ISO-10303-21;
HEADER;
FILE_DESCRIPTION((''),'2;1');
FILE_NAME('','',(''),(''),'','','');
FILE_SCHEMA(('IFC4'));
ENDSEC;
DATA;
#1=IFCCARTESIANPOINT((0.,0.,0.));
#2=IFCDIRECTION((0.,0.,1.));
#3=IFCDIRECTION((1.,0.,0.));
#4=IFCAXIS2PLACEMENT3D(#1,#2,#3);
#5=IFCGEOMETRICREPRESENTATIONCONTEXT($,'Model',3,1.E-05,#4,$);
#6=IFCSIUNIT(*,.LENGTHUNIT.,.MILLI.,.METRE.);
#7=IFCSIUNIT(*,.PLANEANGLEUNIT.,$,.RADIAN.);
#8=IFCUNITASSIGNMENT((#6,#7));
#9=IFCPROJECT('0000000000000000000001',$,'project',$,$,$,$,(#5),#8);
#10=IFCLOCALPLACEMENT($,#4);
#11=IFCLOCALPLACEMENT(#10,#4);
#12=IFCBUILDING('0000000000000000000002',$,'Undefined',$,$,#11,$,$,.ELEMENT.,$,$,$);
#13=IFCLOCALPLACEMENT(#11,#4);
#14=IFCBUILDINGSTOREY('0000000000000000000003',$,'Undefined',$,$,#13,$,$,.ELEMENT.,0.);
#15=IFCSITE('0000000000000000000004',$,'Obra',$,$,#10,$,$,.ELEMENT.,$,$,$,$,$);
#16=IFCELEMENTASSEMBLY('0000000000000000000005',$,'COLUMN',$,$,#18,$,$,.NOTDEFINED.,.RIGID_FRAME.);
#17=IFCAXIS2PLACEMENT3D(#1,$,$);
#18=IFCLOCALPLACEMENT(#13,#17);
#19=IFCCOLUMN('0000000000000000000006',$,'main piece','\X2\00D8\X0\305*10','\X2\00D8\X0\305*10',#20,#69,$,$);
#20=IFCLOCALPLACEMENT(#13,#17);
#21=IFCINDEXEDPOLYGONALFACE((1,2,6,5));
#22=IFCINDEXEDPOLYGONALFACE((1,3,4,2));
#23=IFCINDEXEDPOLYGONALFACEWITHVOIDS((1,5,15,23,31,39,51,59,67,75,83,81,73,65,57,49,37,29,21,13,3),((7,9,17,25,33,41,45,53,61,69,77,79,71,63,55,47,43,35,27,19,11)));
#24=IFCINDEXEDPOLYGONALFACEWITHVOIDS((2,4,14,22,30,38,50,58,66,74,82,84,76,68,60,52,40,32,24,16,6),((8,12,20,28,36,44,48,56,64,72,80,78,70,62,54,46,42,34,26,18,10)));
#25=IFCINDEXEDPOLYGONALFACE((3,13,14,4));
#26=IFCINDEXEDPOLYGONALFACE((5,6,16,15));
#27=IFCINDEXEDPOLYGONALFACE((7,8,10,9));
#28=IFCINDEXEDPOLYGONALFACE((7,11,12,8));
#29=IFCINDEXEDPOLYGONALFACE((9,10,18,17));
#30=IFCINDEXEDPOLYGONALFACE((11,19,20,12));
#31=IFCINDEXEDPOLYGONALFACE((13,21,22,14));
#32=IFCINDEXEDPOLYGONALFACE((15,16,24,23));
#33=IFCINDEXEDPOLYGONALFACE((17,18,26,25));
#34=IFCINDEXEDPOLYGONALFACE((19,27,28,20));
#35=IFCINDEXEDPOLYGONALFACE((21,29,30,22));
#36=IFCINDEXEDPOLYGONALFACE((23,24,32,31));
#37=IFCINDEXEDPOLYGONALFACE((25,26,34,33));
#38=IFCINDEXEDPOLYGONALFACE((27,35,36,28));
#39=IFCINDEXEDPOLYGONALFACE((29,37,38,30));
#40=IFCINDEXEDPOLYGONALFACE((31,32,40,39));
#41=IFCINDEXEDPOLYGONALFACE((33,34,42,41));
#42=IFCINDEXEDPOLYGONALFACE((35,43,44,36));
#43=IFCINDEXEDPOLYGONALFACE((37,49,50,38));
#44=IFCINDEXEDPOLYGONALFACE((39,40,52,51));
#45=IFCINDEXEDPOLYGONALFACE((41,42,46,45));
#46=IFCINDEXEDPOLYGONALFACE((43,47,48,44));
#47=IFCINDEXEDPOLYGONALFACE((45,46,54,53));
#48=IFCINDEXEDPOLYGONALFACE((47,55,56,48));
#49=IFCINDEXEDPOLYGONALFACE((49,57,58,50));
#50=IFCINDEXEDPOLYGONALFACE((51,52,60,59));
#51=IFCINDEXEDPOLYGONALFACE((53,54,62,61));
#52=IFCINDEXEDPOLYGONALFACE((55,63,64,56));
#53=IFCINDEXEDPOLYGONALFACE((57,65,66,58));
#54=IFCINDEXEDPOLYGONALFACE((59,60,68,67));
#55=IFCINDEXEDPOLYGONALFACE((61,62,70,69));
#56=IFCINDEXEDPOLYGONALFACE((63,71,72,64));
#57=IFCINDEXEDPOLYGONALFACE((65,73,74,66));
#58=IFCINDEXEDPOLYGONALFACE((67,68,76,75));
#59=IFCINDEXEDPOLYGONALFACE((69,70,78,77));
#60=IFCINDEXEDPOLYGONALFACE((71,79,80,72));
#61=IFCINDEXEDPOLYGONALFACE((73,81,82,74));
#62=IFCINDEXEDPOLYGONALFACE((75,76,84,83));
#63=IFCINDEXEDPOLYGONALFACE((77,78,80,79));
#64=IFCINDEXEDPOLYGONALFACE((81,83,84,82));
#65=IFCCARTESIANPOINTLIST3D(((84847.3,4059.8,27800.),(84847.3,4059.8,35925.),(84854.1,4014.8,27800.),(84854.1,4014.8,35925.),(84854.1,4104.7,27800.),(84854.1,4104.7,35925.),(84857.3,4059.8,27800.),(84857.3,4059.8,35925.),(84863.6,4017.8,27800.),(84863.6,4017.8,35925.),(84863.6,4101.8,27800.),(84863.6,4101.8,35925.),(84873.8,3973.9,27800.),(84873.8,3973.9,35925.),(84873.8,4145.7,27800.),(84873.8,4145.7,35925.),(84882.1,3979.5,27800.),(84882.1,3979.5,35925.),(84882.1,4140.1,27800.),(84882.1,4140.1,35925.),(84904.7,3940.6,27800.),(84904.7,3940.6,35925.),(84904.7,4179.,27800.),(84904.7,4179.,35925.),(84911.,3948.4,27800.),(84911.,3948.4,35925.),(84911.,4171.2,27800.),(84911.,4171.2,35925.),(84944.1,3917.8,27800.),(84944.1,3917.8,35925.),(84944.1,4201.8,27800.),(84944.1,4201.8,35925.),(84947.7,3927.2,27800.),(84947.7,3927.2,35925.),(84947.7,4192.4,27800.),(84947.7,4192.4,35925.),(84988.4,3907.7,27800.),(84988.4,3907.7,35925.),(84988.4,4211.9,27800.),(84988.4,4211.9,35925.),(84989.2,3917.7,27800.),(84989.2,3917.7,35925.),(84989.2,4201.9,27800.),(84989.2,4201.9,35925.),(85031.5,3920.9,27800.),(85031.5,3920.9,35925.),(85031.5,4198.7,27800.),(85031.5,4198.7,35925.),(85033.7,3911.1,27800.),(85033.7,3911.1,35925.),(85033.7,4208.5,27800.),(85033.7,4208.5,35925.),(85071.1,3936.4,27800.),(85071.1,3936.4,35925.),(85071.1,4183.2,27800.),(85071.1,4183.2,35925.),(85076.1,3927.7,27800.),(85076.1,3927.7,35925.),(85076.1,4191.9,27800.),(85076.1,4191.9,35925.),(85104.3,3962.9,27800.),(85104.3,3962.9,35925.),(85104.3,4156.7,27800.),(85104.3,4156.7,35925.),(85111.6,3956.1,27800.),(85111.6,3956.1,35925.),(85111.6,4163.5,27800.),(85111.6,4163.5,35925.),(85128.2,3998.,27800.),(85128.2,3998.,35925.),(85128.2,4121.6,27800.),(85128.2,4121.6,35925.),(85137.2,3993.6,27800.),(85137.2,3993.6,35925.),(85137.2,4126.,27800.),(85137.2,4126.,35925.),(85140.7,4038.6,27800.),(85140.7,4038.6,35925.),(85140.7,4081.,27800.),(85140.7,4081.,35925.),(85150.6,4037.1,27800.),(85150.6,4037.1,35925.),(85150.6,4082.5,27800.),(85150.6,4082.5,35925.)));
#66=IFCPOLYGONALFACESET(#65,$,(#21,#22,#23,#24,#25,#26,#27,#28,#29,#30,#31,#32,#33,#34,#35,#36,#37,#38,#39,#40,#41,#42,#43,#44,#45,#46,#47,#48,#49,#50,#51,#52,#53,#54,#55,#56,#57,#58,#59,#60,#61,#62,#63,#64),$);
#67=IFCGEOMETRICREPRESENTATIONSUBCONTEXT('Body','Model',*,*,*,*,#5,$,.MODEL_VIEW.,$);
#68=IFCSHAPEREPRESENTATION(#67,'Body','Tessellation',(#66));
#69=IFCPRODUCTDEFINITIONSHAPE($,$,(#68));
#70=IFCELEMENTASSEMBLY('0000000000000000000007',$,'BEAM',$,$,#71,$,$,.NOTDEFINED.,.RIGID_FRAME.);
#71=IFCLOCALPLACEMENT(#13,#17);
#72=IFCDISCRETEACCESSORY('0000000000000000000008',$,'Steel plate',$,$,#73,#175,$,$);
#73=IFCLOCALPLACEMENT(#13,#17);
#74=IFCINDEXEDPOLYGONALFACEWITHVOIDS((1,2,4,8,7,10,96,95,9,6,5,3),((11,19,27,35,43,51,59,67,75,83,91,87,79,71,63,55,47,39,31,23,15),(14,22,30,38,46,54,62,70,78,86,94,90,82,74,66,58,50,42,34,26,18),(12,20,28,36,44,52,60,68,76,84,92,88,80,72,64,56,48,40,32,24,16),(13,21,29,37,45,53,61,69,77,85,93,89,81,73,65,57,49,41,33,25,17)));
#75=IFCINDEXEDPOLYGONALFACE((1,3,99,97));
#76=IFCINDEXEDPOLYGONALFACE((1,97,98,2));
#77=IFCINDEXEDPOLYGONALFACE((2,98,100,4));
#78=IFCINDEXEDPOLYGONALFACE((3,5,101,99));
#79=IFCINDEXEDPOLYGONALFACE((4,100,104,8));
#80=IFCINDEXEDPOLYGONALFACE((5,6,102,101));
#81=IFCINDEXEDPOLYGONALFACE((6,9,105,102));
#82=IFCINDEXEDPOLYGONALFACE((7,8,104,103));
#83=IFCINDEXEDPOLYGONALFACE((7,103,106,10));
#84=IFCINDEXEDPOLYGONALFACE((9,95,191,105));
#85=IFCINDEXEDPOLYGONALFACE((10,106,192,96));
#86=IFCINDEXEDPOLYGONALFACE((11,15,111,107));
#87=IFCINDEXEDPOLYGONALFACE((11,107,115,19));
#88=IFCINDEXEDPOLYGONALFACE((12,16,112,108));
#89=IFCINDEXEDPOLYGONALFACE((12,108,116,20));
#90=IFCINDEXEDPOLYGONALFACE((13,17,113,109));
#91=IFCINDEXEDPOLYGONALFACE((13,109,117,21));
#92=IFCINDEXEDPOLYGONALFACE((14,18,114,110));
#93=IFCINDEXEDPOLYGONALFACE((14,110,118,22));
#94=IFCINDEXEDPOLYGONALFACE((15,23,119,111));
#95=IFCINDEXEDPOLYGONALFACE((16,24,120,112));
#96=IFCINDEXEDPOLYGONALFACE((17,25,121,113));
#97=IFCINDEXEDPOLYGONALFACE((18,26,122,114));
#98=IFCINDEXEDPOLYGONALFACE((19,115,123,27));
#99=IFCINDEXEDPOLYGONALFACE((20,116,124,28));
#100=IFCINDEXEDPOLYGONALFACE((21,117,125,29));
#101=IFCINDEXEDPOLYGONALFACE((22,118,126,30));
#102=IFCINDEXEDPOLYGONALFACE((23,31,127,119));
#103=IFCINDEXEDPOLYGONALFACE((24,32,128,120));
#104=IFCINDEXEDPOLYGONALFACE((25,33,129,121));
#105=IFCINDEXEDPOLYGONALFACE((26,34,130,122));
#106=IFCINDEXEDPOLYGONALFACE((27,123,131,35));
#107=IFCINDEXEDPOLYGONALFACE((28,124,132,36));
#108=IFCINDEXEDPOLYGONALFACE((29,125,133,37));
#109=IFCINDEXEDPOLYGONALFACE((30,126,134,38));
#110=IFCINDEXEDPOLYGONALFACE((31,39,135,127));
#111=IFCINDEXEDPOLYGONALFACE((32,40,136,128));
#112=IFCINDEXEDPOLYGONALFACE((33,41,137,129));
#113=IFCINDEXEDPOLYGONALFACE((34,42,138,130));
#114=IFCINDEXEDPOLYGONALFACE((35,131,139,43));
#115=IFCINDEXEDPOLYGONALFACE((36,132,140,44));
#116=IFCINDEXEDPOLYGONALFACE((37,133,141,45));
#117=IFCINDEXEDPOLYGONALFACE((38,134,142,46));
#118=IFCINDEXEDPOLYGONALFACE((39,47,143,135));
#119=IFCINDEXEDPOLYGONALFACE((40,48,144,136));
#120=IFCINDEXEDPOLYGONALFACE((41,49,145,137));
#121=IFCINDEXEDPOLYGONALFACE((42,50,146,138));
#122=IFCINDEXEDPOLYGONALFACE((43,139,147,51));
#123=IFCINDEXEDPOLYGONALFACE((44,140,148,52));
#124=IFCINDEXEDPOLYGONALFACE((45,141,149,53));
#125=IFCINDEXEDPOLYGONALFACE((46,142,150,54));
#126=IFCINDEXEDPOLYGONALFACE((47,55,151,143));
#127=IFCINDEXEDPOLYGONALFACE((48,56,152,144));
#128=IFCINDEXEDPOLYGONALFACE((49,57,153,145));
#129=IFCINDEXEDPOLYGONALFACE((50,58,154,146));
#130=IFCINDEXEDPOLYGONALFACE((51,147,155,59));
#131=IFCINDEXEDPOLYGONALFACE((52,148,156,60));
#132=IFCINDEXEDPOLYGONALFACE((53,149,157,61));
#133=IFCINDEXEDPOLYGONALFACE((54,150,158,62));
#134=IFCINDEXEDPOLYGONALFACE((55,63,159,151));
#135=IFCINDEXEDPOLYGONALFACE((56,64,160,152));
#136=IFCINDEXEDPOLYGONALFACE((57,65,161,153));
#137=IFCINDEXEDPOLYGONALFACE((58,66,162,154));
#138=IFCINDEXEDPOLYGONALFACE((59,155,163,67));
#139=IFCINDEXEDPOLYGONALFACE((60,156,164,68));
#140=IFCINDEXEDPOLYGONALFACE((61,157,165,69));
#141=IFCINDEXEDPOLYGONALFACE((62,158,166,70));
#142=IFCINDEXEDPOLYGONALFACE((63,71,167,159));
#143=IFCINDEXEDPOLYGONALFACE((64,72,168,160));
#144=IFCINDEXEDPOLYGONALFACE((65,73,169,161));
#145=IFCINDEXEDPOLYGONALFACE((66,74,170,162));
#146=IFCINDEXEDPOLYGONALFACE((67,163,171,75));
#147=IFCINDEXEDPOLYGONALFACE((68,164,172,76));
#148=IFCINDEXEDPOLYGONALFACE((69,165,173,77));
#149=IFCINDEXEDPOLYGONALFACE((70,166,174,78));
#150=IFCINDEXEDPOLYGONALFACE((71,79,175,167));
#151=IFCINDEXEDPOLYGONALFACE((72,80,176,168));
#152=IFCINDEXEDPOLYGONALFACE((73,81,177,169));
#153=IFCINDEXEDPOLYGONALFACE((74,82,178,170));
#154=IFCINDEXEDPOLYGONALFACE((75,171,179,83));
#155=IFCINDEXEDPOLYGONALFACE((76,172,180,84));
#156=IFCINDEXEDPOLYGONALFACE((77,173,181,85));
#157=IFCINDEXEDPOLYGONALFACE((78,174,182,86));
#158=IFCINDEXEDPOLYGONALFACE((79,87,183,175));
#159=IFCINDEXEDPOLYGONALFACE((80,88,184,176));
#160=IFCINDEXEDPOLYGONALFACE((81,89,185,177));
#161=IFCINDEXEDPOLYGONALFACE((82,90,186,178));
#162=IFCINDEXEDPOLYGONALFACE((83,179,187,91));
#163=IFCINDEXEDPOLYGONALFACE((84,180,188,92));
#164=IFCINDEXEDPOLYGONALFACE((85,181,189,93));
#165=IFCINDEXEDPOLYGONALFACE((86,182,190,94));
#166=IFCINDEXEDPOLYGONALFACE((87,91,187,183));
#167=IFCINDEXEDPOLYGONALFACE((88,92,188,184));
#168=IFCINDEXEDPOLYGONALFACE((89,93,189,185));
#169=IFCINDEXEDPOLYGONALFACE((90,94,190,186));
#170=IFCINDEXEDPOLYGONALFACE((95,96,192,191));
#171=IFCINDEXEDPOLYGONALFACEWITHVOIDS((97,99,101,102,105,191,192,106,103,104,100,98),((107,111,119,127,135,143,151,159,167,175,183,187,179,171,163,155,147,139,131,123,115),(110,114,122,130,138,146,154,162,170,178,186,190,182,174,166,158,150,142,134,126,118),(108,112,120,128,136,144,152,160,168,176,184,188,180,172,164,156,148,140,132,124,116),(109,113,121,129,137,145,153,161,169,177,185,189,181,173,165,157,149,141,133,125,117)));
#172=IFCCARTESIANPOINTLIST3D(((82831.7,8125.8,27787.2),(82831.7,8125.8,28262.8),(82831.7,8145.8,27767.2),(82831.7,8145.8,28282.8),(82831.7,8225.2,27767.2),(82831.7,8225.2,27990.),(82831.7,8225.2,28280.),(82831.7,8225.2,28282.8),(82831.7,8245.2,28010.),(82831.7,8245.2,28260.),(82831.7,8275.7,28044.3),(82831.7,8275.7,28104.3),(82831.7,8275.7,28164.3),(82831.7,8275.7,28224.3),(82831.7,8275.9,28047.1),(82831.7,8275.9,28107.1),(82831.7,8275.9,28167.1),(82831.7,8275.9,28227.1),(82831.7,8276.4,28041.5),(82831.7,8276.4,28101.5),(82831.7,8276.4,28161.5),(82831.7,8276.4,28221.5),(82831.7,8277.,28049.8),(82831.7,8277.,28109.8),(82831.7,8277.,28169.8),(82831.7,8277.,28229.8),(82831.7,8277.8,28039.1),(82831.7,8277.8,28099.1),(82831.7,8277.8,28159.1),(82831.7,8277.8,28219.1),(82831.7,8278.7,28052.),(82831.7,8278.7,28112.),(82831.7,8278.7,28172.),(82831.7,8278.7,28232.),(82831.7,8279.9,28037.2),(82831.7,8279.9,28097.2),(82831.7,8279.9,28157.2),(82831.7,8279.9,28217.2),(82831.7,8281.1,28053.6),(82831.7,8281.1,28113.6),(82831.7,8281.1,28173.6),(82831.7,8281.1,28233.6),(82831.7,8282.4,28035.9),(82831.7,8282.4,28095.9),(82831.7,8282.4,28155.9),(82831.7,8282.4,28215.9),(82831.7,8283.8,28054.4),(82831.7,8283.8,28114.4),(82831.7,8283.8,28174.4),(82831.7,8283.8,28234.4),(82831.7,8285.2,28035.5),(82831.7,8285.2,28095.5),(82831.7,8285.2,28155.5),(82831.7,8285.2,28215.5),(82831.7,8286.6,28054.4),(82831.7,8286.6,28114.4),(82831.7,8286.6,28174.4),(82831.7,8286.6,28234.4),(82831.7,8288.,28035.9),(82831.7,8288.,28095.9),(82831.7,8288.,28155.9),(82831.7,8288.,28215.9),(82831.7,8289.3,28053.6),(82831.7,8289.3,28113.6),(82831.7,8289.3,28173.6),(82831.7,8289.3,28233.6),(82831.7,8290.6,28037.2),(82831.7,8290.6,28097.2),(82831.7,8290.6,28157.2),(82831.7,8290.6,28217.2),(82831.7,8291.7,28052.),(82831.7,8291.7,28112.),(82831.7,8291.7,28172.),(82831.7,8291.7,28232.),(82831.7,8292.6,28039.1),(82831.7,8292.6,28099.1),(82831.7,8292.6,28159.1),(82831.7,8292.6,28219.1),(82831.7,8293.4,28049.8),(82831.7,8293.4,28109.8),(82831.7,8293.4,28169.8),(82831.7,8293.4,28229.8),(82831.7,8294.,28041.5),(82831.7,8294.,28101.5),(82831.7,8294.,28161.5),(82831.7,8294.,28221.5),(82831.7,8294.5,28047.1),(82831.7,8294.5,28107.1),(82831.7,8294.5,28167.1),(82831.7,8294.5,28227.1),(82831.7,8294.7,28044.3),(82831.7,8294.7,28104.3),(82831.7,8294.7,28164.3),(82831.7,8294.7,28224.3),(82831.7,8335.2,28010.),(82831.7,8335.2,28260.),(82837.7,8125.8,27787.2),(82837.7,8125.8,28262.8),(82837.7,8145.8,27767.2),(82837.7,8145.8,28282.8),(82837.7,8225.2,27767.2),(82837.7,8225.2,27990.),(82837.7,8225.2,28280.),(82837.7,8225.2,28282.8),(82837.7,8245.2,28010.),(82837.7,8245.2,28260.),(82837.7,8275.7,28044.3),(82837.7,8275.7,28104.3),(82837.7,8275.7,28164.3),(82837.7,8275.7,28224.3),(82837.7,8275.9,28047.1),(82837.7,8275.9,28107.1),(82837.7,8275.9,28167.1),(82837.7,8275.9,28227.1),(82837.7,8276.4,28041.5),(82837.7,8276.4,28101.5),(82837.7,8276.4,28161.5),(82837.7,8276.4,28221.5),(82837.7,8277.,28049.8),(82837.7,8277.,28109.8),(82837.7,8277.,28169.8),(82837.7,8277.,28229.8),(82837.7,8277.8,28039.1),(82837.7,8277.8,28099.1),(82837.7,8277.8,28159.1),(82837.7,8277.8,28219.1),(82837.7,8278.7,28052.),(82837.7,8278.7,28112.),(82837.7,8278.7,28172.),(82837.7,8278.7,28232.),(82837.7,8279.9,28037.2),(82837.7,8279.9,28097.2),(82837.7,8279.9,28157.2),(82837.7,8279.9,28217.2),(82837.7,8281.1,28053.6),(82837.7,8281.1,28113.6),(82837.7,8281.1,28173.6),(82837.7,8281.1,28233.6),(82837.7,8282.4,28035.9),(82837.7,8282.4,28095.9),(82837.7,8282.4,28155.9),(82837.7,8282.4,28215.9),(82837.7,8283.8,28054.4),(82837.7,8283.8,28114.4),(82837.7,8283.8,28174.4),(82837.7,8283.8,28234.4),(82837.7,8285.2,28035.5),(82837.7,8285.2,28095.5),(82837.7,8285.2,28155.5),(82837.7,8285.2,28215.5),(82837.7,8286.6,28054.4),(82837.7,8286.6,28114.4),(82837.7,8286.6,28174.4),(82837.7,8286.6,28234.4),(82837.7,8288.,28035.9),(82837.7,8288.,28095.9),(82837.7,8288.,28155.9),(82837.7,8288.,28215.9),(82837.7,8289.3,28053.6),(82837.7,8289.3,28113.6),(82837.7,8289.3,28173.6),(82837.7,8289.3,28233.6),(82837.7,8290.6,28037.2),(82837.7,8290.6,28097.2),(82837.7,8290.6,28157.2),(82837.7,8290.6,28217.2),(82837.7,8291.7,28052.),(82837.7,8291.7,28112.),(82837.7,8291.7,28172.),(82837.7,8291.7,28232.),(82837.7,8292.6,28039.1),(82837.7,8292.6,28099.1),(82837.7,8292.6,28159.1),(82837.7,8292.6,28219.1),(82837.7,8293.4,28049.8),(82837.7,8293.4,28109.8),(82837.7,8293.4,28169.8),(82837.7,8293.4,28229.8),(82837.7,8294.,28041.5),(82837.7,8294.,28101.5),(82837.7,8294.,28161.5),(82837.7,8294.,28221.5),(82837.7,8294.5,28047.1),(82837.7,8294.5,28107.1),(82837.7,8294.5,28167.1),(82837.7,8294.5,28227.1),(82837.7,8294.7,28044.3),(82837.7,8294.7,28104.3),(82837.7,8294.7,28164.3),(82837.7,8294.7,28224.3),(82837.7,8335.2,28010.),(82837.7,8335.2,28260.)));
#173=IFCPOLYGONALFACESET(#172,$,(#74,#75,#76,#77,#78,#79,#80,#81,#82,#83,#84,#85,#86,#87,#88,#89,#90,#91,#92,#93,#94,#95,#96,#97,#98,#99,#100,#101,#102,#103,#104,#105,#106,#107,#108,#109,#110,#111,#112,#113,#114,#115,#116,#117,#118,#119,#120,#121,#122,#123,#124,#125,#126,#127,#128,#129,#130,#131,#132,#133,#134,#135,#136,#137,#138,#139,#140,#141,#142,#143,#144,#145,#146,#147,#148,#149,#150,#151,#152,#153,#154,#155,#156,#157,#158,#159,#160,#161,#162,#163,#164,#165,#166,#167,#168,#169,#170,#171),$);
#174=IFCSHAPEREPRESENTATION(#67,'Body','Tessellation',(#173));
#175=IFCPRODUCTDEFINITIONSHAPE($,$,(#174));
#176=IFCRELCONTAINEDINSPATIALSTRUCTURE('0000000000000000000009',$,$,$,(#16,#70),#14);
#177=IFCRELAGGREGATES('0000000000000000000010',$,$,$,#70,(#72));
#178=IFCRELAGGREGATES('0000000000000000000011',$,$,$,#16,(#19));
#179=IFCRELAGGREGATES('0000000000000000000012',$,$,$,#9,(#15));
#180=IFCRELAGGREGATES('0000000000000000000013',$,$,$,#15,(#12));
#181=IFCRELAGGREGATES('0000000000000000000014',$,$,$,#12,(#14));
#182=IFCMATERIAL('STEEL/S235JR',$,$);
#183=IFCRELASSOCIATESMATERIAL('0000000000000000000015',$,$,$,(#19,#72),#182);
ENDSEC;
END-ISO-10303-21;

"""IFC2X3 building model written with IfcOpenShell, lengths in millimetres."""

from ifc_helpers import new_model, si_unit, frame, origin_with_axes, origin_2d_with_axis, place, context, subcontext, project, spatial, polyline, circle, hollow_circle, outline, extrude, source, transform, mapped, material, element, aggregate, save


model = new_model("IFC2X3")

# Units and contexts
model_context = context("Model", 3, precision=1e-05, world=origin_with_axes())
body_context = subcontext(model_context, "Body", "Model", "MODEL_VIEW")
ifc_project = project(units=[si_unit("LENGTHUNIT", "METRE", prefix="MILLI"), si_unit("PLANEANGLEUNIT", "RADIAN")], contexts=[model_context])

# Site, building, storey
site_placement = place(None, origin_with_axes())
site = spatial("IfcSite", under=ifc_project, at=site_placement, Name="Obra", CompositionType="ELEMENT")
building_placement = place(site_placement, origin_with_axes())
building = spatial("IfcBuilding", under=site, at=building_placement, Name="Undefined", CompositionType="ELEMENT")
storey_placement = place(building_placement, origin_with_axes())
storey = spatial("IfcBuildingStorey", under=building, at=storey_placement, Name="Undefined", CompositionType="ELEMENT", Elevation=0.0)

# Element assembly, column
assembly_1_placement = place(storey_placement, origin_with_axes())
assembly_1 = element("IfcElementAssembly", 1, at=assembly_1_placement, inside=storey, Name="COLUMN", AssemblyPlace="NOTDEFINED", PredefinedType="RIGID_FRAME")
ifc_material = material(Name="STEEL/S235JR")
column_placement = place(assembly_1_placement, frame((84999.8, 4059.8, 27800.0), z_axis=(0.0, 0.0, 1.0), x_axis=(0.0, 1.0, 0.0)))
column = element("IfcColumn", 2, at=column_placement, material=ifc_material, Name="main piece", Description="Ø305*10", ObjectType="Ø305*10", context=body_context, shape_type="SweptSolid", body=[
    extrude(hollow_circle(Radius=152.5, WallThickness=10.0, at=origin_2d_with_axis()), frame((0.0, 0.0, 8125.0), z_axis=(0.0, 0.0, -1.0), x_axis=(0.0, 1.0, 0.0)), (0.0, 0.0, 1.0), 8125.0),
])

# Element assembly, discrete accessory, opening
assembly_2_placement = place(storey_placement, origin_with_axes())
assembly_2 = element("IfcElementAssembly", 3, at=assembly_2_placement, inside=storey, Name="BEAM", AssemblyPlace="NOTDEFINED", PredefinedType="RIGID_FRAME")
discrete_accessory_1_placement = place(assembly_2_placement, frame((82834.7, 8125.8, 27787.2), z_axis=(1.0, -0.000001, 0.0), x_axis=(0.000001, 0.707107, -0.707107)))
discrete_accessory_1 = element("IfcDiscreteAccessory", 4, at=discrete_accessory_1_placement, material=ifc_material, Name="Steel plate", context=body_context, shape_type="SweptSolid", body=[
    extrude(outline(polyline([(0.0, 0.0), (28.3, 0.0), (84.5, 56.2), (-73.1, 213.7), (-73.1, 242.0), (-9.4, 305.6), (-186.2, 482.4), (-249.9, 418.8), (-278.1, 418.8), (-280.1, 420.8), (-336.3, 364.6), (-336.3, 336.3), (0.0, 0.0)])), frame((0.0, 0.0, -3.0), z_axis=(0.0, 0.0, 1.0), x_axis=(1.0, 0.0, 0.0)), (0.0, 0.0, 1.0), 6.0),
])
shared_shape_1 = source(origin_with_axes(), body_context, "Body", "SweptSolid", [
    extrude(circle(Radius=9.5, at=origin_2d_with_axis()), frame((0.0, -9.8, 0.0), z_axis=(0.0, 1.0, 0.0), x_axis=(1.0, 0.0, 0.0)), (0.0, 0.0, 1.0), 6.2),
])
opening_1_placement = place(assembly_2_placement, frame((82828.0, 8235.2, 28260.0), z_axis=(0.000001, 1.0, 0.0), x_axis=(0.0, 0.0, -1.0)))
element("IfcOpeningElement", 5, at=opening_1_placement, cuts=discrete_accessory_1, ObjectType="Opening", context=body_context, shape_type="MappedRepresentation", body=[
    mapped(shared_shape_1, transform((35.0, 0.0, 50.0))),
    mapped(shared_shape_1, transform((95.0, 0.0, 50.0))),
    mapped(shared_shape_1, transform((155.0, 0.0, 50.0))),
    mapped(shared_shape_1, transform((215.0, 0.0, 50.0))),
])
aggregate(assembly_2, [discrete_accessory_1])

aggregate(assembly_1, [column])

save(model, "model.ifc")
